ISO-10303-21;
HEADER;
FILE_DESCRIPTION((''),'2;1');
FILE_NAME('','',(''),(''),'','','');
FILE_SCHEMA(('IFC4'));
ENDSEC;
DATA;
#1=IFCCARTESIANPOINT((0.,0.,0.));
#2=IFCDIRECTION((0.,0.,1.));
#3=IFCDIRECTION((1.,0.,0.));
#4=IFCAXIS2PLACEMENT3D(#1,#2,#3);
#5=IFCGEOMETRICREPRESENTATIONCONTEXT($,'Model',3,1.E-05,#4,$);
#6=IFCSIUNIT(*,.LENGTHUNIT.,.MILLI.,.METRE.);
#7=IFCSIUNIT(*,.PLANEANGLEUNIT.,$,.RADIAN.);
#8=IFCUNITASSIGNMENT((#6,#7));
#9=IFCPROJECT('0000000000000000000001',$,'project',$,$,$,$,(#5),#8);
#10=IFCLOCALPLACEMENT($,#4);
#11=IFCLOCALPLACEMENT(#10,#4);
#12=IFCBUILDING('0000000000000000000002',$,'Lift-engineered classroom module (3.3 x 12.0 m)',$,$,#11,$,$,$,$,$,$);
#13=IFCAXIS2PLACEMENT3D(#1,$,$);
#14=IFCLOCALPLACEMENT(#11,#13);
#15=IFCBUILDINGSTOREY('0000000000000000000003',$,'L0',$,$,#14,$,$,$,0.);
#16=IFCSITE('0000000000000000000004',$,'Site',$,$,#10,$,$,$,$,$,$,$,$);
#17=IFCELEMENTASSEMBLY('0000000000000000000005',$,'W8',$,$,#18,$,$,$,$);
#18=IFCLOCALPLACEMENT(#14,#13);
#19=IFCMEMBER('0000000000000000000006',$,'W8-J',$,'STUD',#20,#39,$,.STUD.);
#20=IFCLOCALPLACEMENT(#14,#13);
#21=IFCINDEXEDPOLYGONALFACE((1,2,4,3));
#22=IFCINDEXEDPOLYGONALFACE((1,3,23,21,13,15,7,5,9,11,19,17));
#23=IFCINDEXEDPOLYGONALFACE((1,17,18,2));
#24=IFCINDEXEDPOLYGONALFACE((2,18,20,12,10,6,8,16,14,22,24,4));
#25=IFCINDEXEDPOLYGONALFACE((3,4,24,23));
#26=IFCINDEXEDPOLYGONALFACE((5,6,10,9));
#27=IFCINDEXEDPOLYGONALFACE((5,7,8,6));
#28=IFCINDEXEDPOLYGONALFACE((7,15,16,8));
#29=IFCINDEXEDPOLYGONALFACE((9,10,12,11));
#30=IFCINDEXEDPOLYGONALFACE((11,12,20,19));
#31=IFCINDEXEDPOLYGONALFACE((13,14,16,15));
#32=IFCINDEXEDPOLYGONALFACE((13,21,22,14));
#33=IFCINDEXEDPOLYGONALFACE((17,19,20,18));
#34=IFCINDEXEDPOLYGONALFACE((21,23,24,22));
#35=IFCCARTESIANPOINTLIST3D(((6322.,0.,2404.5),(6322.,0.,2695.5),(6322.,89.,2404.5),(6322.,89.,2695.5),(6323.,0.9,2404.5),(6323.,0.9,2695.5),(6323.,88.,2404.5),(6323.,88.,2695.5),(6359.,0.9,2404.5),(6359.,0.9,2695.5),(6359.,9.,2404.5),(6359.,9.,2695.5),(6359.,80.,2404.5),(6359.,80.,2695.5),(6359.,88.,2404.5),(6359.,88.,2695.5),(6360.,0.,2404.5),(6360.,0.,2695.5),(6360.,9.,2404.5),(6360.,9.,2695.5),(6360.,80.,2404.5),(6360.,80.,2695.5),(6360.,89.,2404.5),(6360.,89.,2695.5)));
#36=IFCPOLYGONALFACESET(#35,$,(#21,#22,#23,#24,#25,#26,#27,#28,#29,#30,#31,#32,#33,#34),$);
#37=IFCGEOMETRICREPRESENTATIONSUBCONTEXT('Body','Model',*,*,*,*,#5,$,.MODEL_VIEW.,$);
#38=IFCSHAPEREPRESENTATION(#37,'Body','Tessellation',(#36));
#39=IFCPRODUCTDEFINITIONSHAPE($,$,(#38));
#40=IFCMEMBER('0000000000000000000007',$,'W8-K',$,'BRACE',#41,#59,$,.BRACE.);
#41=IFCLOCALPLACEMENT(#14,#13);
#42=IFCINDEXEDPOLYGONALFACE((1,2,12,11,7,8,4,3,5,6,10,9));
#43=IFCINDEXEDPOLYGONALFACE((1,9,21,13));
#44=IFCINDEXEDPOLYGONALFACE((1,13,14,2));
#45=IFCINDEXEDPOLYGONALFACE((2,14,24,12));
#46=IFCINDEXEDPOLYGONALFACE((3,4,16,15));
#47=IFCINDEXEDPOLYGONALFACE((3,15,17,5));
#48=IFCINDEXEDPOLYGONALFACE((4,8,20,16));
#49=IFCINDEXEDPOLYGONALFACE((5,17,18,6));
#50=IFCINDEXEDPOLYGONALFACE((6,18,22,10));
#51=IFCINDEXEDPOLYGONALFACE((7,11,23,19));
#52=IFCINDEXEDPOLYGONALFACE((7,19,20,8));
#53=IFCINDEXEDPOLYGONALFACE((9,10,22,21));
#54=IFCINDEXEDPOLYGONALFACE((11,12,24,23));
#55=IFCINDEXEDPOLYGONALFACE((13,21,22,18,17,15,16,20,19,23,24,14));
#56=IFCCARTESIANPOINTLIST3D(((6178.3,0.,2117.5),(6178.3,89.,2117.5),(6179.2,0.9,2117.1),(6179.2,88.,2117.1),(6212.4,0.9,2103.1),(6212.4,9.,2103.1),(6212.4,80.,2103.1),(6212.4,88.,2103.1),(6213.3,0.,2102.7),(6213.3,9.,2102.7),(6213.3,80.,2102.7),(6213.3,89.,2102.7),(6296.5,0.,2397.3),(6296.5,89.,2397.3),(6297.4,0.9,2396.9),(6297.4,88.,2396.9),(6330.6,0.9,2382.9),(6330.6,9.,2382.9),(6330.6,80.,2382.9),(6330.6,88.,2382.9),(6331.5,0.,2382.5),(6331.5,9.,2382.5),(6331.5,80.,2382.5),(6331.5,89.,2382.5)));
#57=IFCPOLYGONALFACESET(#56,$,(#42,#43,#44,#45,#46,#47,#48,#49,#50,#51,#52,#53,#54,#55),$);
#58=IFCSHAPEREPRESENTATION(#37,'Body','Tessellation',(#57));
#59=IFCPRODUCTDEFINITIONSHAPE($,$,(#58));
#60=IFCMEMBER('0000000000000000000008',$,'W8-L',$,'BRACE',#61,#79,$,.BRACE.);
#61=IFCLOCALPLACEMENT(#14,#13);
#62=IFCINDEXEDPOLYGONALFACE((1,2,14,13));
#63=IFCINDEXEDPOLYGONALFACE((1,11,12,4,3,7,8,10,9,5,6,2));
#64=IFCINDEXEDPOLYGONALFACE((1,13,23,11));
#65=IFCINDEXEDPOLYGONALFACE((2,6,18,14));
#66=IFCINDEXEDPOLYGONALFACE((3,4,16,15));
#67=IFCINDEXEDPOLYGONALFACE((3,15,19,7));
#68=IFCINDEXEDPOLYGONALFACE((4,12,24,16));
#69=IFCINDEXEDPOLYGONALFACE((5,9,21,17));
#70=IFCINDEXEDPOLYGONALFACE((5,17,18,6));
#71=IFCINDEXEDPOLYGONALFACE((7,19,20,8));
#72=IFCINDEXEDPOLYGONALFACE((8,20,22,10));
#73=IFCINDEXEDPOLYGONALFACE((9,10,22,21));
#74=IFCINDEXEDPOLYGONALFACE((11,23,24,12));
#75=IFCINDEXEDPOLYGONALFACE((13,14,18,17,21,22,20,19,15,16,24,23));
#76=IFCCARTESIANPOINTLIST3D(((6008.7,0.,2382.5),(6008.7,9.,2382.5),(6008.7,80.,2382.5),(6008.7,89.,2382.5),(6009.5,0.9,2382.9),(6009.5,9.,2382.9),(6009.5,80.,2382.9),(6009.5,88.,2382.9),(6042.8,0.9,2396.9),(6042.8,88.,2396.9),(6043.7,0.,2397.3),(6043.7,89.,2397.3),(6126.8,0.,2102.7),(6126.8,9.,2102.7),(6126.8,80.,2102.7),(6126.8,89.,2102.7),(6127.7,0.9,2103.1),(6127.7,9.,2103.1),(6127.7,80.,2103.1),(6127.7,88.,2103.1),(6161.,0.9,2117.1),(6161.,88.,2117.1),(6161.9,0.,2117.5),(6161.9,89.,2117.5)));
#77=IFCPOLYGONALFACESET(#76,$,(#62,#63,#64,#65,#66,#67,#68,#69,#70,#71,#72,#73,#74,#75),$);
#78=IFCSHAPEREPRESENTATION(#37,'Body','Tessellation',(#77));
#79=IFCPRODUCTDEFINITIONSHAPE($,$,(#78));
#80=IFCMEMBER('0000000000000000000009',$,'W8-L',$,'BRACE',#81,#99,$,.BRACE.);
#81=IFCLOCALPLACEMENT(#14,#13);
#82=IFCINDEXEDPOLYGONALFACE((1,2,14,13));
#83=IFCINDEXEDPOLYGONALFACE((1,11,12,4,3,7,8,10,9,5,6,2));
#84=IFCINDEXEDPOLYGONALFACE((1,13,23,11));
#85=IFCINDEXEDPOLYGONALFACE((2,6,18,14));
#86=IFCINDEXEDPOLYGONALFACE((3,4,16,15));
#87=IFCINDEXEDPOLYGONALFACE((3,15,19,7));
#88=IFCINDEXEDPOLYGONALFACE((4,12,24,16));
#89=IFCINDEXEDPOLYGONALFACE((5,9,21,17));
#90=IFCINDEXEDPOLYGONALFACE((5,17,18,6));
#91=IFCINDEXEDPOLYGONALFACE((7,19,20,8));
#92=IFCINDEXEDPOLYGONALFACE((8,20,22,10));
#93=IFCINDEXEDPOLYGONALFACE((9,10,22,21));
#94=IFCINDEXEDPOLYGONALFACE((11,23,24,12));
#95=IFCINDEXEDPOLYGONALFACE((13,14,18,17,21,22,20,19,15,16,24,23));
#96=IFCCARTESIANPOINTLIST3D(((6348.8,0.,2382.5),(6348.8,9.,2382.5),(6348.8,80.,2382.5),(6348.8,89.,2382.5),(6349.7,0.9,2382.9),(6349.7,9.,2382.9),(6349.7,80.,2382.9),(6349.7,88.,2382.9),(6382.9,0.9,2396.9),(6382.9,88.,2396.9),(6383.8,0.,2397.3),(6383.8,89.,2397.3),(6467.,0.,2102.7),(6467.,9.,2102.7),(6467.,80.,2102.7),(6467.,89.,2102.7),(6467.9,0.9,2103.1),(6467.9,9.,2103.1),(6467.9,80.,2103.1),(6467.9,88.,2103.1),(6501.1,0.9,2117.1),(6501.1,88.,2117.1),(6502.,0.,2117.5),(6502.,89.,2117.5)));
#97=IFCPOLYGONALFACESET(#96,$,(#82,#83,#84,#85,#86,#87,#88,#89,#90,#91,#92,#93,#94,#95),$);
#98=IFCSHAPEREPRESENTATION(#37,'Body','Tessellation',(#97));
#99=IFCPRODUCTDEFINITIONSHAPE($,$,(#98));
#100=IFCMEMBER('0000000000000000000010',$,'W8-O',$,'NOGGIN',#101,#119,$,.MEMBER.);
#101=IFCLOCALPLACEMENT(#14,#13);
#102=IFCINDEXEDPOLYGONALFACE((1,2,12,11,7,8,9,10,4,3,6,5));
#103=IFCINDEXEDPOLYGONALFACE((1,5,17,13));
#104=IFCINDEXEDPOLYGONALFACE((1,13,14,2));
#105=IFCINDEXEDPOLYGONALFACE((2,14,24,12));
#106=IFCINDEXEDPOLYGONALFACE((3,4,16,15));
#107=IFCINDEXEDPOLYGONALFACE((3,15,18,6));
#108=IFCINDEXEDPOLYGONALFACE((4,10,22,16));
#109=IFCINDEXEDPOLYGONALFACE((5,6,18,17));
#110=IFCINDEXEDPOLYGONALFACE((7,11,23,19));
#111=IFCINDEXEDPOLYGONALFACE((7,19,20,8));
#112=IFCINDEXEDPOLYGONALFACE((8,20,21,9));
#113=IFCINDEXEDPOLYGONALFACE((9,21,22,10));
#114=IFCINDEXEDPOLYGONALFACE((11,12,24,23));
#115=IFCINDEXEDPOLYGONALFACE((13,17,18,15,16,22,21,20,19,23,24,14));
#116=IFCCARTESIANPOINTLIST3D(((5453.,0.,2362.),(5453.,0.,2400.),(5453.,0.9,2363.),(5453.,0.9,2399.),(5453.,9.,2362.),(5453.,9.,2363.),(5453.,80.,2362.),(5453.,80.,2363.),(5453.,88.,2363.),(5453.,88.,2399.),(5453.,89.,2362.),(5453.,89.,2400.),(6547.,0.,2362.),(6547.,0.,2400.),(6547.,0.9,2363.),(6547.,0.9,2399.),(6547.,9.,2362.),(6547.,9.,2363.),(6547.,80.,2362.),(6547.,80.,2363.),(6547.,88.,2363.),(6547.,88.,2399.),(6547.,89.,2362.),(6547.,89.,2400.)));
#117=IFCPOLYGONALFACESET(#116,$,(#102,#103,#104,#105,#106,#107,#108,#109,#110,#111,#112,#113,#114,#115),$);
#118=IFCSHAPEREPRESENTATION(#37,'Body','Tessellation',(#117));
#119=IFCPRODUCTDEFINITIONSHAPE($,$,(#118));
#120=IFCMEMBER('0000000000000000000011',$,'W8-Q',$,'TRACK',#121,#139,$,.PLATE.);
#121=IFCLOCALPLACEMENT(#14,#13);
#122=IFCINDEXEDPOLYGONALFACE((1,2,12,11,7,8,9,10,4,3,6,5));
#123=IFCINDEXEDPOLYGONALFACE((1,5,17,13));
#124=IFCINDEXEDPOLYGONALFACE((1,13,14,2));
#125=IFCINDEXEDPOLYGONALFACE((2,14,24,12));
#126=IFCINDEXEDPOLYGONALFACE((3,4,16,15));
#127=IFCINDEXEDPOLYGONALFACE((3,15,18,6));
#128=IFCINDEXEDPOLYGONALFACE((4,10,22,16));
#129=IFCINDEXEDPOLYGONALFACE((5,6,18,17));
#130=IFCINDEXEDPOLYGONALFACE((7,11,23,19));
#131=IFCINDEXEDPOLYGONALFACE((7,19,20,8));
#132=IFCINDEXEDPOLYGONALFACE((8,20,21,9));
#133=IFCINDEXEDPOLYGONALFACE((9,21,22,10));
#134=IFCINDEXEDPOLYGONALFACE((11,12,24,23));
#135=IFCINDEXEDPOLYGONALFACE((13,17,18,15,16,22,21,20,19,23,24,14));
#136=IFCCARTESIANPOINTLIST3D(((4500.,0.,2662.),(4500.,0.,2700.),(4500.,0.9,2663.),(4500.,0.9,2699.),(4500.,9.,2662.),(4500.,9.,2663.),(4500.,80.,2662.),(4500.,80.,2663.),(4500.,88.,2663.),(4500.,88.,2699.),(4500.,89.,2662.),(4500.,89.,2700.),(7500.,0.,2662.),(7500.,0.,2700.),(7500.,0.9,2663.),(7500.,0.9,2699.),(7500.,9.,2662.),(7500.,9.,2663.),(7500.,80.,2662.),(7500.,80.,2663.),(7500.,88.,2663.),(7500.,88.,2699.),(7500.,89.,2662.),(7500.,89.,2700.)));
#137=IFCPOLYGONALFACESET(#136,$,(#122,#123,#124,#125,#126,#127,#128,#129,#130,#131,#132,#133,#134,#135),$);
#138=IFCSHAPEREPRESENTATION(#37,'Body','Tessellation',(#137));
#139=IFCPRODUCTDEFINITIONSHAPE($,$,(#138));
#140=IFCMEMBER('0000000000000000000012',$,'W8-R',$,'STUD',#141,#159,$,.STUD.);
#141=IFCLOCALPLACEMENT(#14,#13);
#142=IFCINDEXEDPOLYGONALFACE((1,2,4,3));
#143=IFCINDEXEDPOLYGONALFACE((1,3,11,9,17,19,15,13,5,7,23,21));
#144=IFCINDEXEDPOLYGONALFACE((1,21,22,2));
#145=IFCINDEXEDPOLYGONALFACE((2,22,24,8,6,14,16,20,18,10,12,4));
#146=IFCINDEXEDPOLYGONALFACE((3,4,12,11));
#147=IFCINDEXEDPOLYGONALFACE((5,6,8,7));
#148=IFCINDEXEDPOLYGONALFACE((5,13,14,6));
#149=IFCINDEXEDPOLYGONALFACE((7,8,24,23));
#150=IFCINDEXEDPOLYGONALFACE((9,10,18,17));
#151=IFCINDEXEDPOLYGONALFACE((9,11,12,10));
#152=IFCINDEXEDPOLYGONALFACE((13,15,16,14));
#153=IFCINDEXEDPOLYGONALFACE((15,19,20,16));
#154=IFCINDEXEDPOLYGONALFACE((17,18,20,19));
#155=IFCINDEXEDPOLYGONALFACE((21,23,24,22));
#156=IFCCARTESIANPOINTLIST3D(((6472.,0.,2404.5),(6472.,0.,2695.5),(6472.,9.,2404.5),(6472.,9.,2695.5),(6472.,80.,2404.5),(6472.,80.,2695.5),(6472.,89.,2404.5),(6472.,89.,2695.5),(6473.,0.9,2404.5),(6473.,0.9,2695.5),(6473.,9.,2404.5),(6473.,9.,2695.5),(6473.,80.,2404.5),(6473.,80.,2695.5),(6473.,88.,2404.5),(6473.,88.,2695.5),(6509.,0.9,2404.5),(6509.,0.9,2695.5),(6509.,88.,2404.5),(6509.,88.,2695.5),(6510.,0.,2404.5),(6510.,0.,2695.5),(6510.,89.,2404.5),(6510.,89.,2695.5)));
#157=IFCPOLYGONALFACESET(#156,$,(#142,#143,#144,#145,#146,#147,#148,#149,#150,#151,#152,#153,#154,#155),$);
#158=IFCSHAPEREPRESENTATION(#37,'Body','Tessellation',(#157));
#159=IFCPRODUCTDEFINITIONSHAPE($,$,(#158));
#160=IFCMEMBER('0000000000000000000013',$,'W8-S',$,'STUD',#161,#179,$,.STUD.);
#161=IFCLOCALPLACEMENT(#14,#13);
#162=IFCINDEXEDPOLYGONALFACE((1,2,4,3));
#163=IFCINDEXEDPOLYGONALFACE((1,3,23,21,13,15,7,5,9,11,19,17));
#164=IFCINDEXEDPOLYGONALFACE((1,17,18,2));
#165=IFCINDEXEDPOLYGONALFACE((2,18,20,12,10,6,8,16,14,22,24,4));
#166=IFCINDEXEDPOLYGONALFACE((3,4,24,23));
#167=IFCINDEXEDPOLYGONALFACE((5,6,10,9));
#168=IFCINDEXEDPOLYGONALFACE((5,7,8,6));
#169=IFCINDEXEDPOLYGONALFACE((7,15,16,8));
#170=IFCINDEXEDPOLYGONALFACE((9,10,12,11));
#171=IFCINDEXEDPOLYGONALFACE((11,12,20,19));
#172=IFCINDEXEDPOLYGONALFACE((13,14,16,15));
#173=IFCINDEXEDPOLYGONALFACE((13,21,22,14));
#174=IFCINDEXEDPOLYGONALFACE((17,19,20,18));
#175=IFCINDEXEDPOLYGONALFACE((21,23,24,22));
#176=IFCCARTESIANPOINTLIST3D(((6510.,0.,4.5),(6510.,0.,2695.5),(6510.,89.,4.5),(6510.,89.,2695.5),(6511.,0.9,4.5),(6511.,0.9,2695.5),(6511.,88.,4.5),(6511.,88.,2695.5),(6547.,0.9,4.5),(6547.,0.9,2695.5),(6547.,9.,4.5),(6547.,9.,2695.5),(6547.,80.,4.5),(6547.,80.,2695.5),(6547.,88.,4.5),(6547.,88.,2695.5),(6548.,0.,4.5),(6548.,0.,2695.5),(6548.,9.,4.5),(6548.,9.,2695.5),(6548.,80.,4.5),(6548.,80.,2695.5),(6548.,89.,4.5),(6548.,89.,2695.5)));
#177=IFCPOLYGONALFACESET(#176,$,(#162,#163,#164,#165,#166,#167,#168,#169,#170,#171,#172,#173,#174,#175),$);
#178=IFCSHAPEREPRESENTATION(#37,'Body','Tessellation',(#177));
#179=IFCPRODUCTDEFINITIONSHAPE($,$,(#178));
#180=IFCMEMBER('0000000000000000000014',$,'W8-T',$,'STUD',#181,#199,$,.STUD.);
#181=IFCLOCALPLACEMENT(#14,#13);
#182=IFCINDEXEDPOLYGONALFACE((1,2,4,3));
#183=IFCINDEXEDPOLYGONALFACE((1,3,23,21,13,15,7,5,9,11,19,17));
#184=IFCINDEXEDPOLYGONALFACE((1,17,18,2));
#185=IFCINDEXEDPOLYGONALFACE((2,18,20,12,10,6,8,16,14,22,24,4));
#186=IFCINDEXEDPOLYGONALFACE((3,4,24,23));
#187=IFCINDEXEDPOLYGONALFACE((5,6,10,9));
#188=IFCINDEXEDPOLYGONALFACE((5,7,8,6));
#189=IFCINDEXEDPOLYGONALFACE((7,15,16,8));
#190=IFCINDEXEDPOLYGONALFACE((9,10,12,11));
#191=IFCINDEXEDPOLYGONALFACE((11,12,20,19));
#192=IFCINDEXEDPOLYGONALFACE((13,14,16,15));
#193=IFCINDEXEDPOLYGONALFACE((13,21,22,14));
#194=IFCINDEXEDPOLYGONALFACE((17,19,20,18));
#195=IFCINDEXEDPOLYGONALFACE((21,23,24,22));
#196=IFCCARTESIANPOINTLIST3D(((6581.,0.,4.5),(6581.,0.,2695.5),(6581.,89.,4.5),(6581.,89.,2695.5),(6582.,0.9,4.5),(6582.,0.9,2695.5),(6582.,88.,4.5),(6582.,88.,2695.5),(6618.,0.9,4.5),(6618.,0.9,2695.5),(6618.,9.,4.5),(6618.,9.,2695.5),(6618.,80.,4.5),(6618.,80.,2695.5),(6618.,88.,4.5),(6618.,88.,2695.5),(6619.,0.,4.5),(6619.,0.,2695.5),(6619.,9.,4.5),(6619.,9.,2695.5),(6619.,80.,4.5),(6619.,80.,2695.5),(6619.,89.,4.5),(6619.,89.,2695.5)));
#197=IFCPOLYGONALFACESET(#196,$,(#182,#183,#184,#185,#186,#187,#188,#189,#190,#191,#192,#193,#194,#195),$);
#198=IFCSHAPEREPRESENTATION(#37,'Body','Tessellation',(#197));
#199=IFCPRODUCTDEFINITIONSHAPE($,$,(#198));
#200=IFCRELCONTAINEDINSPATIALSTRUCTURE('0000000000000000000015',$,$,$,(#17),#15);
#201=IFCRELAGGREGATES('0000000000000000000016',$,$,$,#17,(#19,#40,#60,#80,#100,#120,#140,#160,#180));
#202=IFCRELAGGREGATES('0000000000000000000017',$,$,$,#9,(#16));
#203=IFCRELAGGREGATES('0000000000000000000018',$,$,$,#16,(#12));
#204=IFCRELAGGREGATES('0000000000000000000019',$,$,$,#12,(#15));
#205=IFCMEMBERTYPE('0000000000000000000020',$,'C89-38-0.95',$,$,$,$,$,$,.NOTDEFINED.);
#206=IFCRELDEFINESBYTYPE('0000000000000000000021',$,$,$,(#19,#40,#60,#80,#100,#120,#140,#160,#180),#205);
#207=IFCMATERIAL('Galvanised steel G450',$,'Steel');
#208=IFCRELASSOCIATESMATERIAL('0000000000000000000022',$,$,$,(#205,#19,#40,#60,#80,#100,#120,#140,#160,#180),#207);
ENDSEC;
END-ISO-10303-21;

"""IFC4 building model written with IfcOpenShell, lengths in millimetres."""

from ifc_helpers import new_model, si_unit, frame, origin, origin_with_axes, origin_2d, place, context, subcontext, project, spatial, c_section, extrude, material, material_profile, profile_set, profile_usage, type_object, element, aggregate, save


model = new_model("IFC4")

# Units and contexts
model_context = context("Model", 3, precision=1e-05, world=origin_with_axes())
body_context = subcontext(model_context, "Body", "Model", "MODEL_VIEW")
ifc_project = project(units=[si_unit("LENGTHUNIT", "METRE", prefix="MILLI"), si_unit("PLANEANGLEUNIT", "RADIAN")], contexts=[model_context])

# Site, building, storey
site_placement = place(None, origin_with_axes())
site = spatial("IfcSite", under=ifc_project, at=site_placement, Name="Site")
building_placement = place(site_placement, origin_with_axes())
building = spatial("IfcBuilding", under=site, at=building_placement, Name="Lift-engineered classroom module (3.3 x 12.0 m)")
storey_placement = place(building_placement, origin())
storey = spatial("IfcBuildingStorey", under=building, at=storey_placement, Name="L0", Elevation=0.0)

# Element assembly, members
assembly_1_placement = place(storey_placement, frame((4500.0, 44.5, 0.0)))
assembly_1 = element("IfcElementAssembly", 1, at=assembly_1_placement, inside=storey, Name="W8")
ifc_material = material(Name="Galvanised steel G450", Category="Steel")
ifc_material_profile = material_profile(ifc_material, c_section(Depth=89.0, Width=38.0, WallThickness=0.9, Girth=9.0, at=origin_2d()), Name="C89-38-0.95")
ifc_profile_set = profile_set([ifc_material_profile], Name="C89-38-0.95")
ifc_profile_usage = profile_usage(ifc_profile_set)
member_type = type_object("IfcMemberType", Name="C89-38-0.95", PredefinedType="NOTDEFINED", material=ifc_profile_set)
member_1_placement = place(assembly_1_placement, frame((1841.0, 0.0, 2695.5), z_axis=(0.0, 0.0, -1.0), x_axis=(1.0, 0.0, 0.0)))
member_1 = element("IfcMember", 2, at=member_1_placement, type_object=member_type, material=ifc_profile_usage, Name="W8-J", ObjectType="STUD", PredefinedType="STUD", context=body_context, shape_type="SweptSolid", body=[
    extrude(c_section(Depth=89.0, Width=38.0, WallThickness=0.9, Girth=9.0, at=origin_2d()), origin(), (0.0, 0.0, 1.0), 291.0),
])
member_2_placement = place(assembly_1_placement, frame((1814.0, 0.0, 2389.9), z_axis=(-0.389106, 0.0, -0.921193), x_axis=(0.921193, 0.0, -0.389106)))
member_2 = element("IfcMember", 3, at=member_2_placement, type_object=member_type, material=ifc_profile_usage, Name="W8-K", ObjectType="BRACE", PredefinedType="BRACE", context=body_context, shape_type="SweptSolid", body=[
    extrude(c_section(Depth=89.0, Width=38.0, WallThickness=0.9, Girth=9.0, at=origin_2d()), origin(), (0.0, 0.0, 1.0), 303.8),
])
member_3_placement = place(assembly_1_placement, frame((1644.4, 0.0, 2110.1), z_axis=(-0.389106, 0.0, 0.921193), x_axis=(-0.921193, 0.0, -0.389106)))
member_3 = element("IfcMember", 4, at=member_3_placement, type_object=member_type, material=ifc_profile_usage, Name="W8-L", ObjectType="BRACE", PredefinedType="BRACE", context=body_context, shape_type="SweptSolid", body=[
    extrude(c_section(Depth=89.0, Width=38.0, WallThickness=0.9, Girth=9.0, at=origin_2d()), origin(), (0.0, 0.0, 1.0), 303.8),
])
member_4_placement = place(assembly_1_placement, frame((1984.5, 0.0, 2110.1), z_axis=(-0.389106, 0.0, 0.921193), x_axis=(-0.921193, 0.0, -0.389106)))
member_4 = element("IfcMember", 5, at=member_4_placement, type_object=member_type, material=ifc_profile_usage, Name="W8-L", ObjectType="BRACE", PredefinedType="BRACE", context=body_context, shape_type="SweptSolid", body=[
    extrude(c_section(Depth=89.0, Width=38.0, WallThickness=0.9, Girth=9.0, at=origin_2d()), origin(), (0.0, 0.0, 1.0), 303.8),
])
member_5_placement = place(assembly_1_placement, frame((2047.1, 0.0, 2381.0), z_axis=(-1.0, 0.0, 0.0), x_axis=(0.0, 0.0, -1.0)))
member_5 = element("IfcMember", 6, at=member_5_placement, type_object=member_type, material=ifc_profile_usage, Name="W8-O", ObjectType="NOGGIN", PredefinedType="MEMBER", context=body_context, shape_type="SweptSolid", body=[
    extrude(c_section(Depth=89.0, Width=38.0, WallThickness=0.9, Girth=9.0, at=origin_2d()), origin(), (0.0, 0.0, 1.0), 1094.1),
])
member_6_placement = place(assembly_1_placement, frame((3000.0, 0.0, 2681.0), z_axis=(-1.0, 0.0, 0.0), x_axis=(0.0, 0.0, -1.0)))
member_6 = element("IfcMember", 7, at=member_6_placement, type_object=member_type, material=ifc_profile_usage, Name="W8-Q", ObjectType="TRACK", PredefinedType="PLATE", context=body_context, shape_type="SweptSolid", body=[
    extrude(c_section(Depth=89.0, Width=38.0, WallThickness=0.9, Girth=9.0, at=origin_2d()), origin(), (0.0, 0.0, 1.0), 3000.0),
])
member_7_placement = place(assembly_1_placement, frame((1991.0, 0.0, 2404.5), z_axis=(0.0, 0.0, 1.0), x_axis=(-1.0, 0.0, 0.0)))
member_7 = element("IfcMember", 8, at=member_7_placement, type_object=member_type, material=ifc_profile_usage, Name="W8-R", ObjectType="STUD", PredefinedType="STUD", context=body_context, shape_type="SweptSolid", body=[
    extrude(c_section(Depth=89.0, Width=38.0, WallThickness=0.9, Girth=9.0, at=origin_2d()), origin(), (0.0, 0.0, 1.0), 291.0),
])
member_8_placement = place(assembly_1_placement, frame((2029.0, 0.0, 2695.5), z_axis=(0.0, 0.0, -1.0), x_axis=(1.0, 0.0, 0.0)))
member_8 = element("IfcMember", 9, at=member_8_placement, type_object=member_type, material=ifc_profile_usage, Name="W8-S", ObjectType="STUD", PredefinedType="STUD", context=body_context, shape_type="SweptSolid", body=[
    extrude(c_section(Depth=89.0, Width=38.0, WallThickness=0.9, Girth=9.0, at=origin_2d()), origin(), (0.0, 0.0, 1.0), 2691.0),
])
member_9_placement = place(assembly_1_placement, frame((2100.0, 0.0, 2695.5), z_axis=(0.0, 0.0, -1.0), x_axis=(1.0, 0.0, 0.0)))
member_9 = element("IfcMember", 10, at=member_9_placement, type_object=member_type, material=ifc_profile_usage, Name="W8-T", ObjectType="STUD", PredefinedType="STUD", context=body_context, shape_type="SweptSolid", body=[
    extrude(c_section(Depth=89.0, Width=38.0, WallThickness=0.9, Girth=9.0, at=origin_2d()), origin(), (0.0, 0.0, 1.0), 2691.0),
])
aggregate(assembly_1, [member_1, member_2, member_3, member_4, member_5, member_6, member_7, member_8, member_9])

save(model, "model.ifc")
